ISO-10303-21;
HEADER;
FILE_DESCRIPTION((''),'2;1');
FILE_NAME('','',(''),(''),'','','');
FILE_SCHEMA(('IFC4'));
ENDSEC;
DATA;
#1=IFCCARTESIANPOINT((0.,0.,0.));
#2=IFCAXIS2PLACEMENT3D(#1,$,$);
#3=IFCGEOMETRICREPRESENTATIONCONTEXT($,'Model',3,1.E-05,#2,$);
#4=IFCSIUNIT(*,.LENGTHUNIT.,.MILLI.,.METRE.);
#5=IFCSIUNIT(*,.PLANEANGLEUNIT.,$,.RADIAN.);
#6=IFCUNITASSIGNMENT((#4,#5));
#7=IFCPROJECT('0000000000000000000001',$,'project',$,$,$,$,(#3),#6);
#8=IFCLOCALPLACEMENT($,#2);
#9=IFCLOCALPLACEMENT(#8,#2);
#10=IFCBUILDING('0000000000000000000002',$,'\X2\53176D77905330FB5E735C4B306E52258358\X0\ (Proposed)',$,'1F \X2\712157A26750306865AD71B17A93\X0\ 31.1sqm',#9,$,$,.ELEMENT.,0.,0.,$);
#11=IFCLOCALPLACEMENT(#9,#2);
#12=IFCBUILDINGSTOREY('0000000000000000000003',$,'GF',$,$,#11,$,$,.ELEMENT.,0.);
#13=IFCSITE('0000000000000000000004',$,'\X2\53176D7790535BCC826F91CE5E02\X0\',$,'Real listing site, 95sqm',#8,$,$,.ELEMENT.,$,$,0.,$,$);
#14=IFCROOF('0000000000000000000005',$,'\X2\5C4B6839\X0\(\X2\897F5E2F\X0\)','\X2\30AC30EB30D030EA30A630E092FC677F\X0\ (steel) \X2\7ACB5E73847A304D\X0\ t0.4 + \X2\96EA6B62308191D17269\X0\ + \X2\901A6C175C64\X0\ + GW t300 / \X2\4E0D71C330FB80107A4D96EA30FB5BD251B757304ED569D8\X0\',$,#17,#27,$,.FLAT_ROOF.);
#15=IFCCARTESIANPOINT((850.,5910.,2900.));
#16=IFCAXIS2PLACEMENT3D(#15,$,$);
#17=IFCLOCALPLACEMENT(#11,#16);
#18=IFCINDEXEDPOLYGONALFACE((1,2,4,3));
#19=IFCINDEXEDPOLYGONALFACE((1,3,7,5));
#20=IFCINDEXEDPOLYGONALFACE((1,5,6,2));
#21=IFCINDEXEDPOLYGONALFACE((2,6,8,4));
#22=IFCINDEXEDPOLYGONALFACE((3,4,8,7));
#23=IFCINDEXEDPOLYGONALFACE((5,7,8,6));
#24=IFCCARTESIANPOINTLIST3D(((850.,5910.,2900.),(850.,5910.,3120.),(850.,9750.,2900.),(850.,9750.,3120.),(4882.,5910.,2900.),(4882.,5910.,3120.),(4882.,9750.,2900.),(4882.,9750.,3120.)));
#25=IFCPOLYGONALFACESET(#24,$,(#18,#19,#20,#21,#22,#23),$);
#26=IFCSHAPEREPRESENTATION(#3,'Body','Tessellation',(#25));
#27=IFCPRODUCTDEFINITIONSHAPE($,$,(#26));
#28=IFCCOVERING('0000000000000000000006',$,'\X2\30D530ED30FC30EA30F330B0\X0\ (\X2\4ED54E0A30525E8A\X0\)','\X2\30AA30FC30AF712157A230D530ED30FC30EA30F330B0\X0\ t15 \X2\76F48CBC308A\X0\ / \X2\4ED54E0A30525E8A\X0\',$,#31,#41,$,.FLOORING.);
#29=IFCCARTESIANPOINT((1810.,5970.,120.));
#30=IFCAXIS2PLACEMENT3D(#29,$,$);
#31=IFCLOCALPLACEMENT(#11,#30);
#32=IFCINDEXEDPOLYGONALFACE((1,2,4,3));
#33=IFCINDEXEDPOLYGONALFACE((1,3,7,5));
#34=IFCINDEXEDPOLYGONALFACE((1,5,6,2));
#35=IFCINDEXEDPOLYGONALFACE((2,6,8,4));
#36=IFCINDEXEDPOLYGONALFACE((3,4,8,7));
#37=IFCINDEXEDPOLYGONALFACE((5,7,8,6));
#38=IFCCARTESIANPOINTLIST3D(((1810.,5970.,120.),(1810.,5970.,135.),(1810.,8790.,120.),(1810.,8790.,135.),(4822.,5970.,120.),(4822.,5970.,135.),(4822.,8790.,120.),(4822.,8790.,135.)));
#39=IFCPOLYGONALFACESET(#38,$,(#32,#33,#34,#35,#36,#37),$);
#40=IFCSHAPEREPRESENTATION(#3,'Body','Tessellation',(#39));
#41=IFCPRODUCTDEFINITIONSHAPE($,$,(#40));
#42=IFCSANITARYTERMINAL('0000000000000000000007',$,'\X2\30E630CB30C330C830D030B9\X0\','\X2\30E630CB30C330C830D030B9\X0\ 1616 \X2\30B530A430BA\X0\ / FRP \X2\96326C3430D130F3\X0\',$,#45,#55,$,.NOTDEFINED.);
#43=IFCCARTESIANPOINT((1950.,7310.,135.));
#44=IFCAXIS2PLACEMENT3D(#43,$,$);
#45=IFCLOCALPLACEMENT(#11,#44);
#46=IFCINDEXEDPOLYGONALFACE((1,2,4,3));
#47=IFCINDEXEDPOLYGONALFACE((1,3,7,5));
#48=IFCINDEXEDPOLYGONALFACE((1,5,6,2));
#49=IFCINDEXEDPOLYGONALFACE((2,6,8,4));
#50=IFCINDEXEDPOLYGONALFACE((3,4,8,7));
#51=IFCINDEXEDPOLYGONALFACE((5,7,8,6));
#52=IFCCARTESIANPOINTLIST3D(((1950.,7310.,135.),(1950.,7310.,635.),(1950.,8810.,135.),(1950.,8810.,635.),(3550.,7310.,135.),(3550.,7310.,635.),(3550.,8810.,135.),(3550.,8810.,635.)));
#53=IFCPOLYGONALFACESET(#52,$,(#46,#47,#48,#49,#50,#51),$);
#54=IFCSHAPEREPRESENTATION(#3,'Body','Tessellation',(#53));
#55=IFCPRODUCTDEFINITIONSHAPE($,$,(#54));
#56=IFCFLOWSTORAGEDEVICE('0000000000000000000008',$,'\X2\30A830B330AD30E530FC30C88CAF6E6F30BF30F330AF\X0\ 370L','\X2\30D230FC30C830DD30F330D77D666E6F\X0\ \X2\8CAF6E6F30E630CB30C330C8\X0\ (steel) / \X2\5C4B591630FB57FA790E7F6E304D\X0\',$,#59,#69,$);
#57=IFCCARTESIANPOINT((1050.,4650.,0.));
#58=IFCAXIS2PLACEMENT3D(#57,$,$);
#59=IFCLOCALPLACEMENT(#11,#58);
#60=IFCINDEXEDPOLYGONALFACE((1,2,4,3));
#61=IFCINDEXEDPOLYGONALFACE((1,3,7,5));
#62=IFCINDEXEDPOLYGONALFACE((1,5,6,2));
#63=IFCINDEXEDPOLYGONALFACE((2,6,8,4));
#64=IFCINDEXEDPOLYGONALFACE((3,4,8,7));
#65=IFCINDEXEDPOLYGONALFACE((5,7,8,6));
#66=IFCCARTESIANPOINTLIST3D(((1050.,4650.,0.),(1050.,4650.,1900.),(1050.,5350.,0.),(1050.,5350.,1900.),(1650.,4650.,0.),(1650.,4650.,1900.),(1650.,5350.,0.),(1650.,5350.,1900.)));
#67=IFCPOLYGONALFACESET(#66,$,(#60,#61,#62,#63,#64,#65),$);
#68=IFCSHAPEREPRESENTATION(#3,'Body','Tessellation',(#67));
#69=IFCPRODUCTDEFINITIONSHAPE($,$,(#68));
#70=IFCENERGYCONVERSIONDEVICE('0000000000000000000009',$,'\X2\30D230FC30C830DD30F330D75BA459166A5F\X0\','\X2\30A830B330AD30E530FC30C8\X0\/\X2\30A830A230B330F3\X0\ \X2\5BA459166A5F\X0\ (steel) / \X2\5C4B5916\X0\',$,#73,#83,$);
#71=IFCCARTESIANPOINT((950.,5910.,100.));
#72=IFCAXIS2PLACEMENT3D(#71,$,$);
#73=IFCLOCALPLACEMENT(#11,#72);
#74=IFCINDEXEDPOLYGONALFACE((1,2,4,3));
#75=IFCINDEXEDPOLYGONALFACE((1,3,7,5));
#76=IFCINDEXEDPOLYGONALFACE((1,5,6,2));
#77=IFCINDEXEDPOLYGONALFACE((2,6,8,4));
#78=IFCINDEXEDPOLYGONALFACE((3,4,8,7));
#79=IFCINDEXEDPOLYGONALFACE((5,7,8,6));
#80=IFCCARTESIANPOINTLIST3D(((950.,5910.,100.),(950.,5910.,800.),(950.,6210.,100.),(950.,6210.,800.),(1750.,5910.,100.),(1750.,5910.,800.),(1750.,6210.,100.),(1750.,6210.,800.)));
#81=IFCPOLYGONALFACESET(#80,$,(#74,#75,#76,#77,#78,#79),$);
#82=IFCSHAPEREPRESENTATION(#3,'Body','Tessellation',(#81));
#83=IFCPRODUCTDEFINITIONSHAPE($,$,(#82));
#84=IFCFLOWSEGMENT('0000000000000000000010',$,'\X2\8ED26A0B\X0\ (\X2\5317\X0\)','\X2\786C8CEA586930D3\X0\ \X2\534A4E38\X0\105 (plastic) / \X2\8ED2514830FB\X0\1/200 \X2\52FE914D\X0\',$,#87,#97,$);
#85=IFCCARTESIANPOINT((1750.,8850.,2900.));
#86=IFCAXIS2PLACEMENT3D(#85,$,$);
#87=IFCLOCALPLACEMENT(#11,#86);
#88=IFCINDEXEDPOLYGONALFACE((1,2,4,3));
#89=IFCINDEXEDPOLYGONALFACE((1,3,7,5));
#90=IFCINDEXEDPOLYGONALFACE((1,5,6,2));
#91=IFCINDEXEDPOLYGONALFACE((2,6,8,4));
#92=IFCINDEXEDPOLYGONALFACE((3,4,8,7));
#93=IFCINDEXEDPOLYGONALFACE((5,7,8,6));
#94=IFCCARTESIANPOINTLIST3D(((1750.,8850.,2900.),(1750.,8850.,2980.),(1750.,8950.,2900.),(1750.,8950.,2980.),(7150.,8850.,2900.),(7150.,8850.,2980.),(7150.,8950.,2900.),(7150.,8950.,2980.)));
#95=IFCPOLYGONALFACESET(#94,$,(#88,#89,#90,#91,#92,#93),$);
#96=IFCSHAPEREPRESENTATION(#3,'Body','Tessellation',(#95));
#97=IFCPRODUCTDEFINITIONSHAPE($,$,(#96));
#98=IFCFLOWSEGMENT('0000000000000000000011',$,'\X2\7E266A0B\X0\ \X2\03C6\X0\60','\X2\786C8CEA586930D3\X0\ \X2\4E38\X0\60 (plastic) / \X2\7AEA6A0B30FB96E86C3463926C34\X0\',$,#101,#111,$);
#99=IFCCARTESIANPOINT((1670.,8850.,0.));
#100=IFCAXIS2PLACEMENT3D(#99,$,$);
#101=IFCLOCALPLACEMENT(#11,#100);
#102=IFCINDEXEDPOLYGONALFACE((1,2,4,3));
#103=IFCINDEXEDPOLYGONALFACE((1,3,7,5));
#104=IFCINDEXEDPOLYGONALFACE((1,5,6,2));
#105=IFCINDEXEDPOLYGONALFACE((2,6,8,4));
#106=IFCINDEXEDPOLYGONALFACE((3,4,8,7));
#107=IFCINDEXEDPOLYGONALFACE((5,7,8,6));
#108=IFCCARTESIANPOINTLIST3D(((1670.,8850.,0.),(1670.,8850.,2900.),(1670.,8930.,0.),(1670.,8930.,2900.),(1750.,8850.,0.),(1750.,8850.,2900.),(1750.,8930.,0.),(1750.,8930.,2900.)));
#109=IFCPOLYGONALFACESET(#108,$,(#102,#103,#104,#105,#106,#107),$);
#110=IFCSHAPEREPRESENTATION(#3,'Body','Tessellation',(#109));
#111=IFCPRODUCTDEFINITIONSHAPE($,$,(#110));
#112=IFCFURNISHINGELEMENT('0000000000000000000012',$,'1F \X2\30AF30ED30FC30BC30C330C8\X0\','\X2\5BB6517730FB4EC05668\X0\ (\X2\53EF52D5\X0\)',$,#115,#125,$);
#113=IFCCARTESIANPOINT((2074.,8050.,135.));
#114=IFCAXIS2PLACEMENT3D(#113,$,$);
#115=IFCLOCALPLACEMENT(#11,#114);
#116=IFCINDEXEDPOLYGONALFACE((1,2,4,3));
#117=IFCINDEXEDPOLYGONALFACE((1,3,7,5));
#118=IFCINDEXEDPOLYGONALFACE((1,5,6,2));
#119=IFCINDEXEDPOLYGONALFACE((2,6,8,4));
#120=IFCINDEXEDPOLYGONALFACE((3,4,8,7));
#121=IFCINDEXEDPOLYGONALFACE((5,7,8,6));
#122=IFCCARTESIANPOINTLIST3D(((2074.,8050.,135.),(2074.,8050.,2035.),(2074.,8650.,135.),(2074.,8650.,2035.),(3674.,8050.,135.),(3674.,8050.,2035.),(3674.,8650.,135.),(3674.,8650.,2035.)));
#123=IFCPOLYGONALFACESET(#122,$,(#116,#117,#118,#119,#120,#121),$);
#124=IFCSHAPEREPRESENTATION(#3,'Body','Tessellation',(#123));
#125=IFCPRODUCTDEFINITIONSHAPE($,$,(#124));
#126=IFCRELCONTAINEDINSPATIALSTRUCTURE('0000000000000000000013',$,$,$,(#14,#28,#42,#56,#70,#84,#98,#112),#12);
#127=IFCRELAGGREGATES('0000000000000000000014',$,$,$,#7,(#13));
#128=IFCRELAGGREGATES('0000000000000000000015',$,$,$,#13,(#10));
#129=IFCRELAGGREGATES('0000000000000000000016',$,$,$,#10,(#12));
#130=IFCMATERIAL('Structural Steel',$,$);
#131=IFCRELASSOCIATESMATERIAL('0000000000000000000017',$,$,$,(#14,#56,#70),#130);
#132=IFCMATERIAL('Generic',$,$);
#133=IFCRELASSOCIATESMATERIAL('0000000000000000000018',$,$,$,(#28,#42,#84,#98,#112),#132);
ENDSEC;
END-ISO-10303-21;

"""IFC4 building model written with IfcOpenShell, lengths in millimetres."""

from ifc_helpers import new_model, si_unit, frame, frame_2d, origin, place, context, project, spatial, rectangle, extrude, material, element, save


model = new_model("IFC4")

# Units and contexts
model_context = context("Model", 3, precision=1e-05, world=origin())
ifc_project = project(units=[si_unit("LENGTHUNIT", "METRE", prefix="MILLI"), si_unit("PLANEANGLEUNIT", "RADIAN")], contexts=[model_context])

# Site, building, storey
site_placement = place(None, origin())
site = spatial("IfcSite", under=ifc_project, at=site_placement, Name="北海道富良野市", ObjectType="Real listing site, 95sqm", CompositionType="ELEMENT", RefElevation=0.0)
building_placement = place(site_placement, origin())
building = spatial("IfcBuilding", under=site, at=building_placement, Name="北海道・平屋の別荘 (Proposed)", ObjectType="1F 無垢材と断熱窓 31.1sqm", CompositionType="ELEMENT", ElevationOfRefHeight=0.0, ElevationOfTerrain=0.0)
storey_placement = place(building_placement, origin())
storey = spatial("IfcBuildingStorey", under=building, at=storey_placement, Name="GF", CompositionType="ELEMENT", Elevation=0.0)

# Roof
ifc_material_1 = material(Name="Structural Steel")
roof_placement = place(storey_placement, frame((850.0, 5910.0, 2900.0)))
element("IfcRoof", 1, at=roof_placement, inside=storey, material=ifc_material_1, Name="屋根(西帯)", Description="ガルバリウム鋼板 (steel) 立平葺き t0.4 + 雪止め金物 + 通気層 + GW t300 / 不燃・耐積雪・寒冷地仕様", PredefinedType="FLAT_ROOF", context=model_context, shape_type="SweptSolid", body=[
    extrude(rectangle(XDim=4032.0, YDim=3840.0, at=frame_2d((2016.0, 1920.0))), frame((850.0, 5910.0, 2900.0)), (0.0, 0.0, 1.0), 220.0),
])

# Covering
ifc_material_2 = material(Name="Generic")
covering_placement = place(storey_placement, frame((1810.0, 5970.0, 120.0)))
element("IfcCovering", 2, at=covering_placement, inside=storey, material=ifc_material_2, Name="フローリング (仕上げ床)", Description="オーク無垢フローリング t15 直貼り / 仕上げ床", PredefinedType="FLOORING", context=model_context, shape_type="SweptSolid", body=[
    extrude(rectangle(XDim=3012.0, YDim=2820.0, at=frame_2d((1506.0, 1410.0))), frame((1810.0, 5970.0, 120.0)), (0.0, 0.0, 1.0), 15.0),
])

# Sanitary terminal
sanitary_terminal_placement = place(storey_placement, frame((1950.0, 7310.0, 135.0)))
element("IfcSanitaryTerminal", 3, at=sanitary_terminal_placement, inside=storey, material=ifc_material_2, Name="ユニットバス", Description="ユニットバス 1616 サイズ / FRP 防水パン", PredefinedType="NOTDEFINED", context=model_context, shape_type="SweptSolid", body=[
    extrude(rectangle(XDim=1600.0, YDim=1500.0, at=frame_2d((800.0, 750.0))), frame((1950.0, 7310.0, 135.0)), (0.0, 0.0, 1.0), 500.0),
])

# Flow storage device
flow_storage_device_placement = place(storey_placement, frame((1050.0, 4650.0, 0.0)))
element("IfcFlowStorageDevice", 4, at=flow_storage_device_placement, inside=storey, material=ifc_material_1, Name="エコキュート貯湯タンク 370L", Description="ヒートポンプ給湯 貯湯ユニット (steel) / 屋外・基礎置き", context=model_context, shape_type="SweptSolid", body=[
    extrude(rectangle(XDim=600.0, YDim=700.0, at=frame_2d((300.0, 350.0))), frame((1050.0, 4650.0, 0.0)), (0.0, 0.0, 1.0), 1900.0),
])

# Energy conversion device
energy_conversion_device_placement = place(storey_placement, frame((950.0, 5910.0, 100.0)))
element("IfcEnergyConversionDevice", 5, at=energy_conversion_device_placement, inside=storey, material=ifc_material_1, Name="ヒートポンプ室外機", Description="エコキュート/エアコン 室外機 (steel) / 屋外", context=model_context, shape_type="SweptSolid", body=[
    extrude(rectangle(XDim=800.0, YDim=300.0, at=frame_2d((400.0, 150.0))), frame((950.0, 5910.0, 100.0)), (0.0, 0.0, 1.0), 700.0),
])

# Flow segments
flow_segment_1_placement = place(storey_placement, frame((1750.0, 8850.0, 2900.0)))
element("IfcFlowSegment", 6, at=flow_segment_1_placement, inside=storey, material=ifc_material_2, Name="軒樋 (北)", Description="硬質塩ビ 半丸105 (plastic) / 軒先・1/200 勾配", context=model_context, shape_type="SweptSolid", body=[
    extrude(rectangle(XDim=5400.0, YDim=100.0, at=frame_2d((2700.0, 50.0))), frame((1750.0, 8850.0, 2900.0)), (0.0, 0.0, 1.0), 80.0),
])
flow_segment_2_placement = place(storey_placement, frame((1670.0, 8850.0, 0.0)))
element("IfcFlowSegment", 7, at=flow_segment_2_placement, inside=storey, material=ifc_material_2, Name="縦樋 φ60", Description="硬質塩ビ 丸60 (plastic) / 竪樋・雨水排水", context=model_context, shape_type="SweptSolid", body=[
    extrude(rectangle(XDim=80.0, YDim=80.0, at=frame_2d((40.0, 40.0))), frame((1670.0, 8850.0, 0.0)), (0.0, 0.0, 1.0), 2900.0),
])

# Furnishing element
furnishing_placement = place(storey_placement, frame((2074.0, 8050.0, 135.0)))
element("IfcFurnishingElement", 8, at=furnishing_placement, inside=storey, material=ifc_material_2, Name="1F クローゼット", Description="家具・什器 (可動)", context=model_context, shape_type="SweptSolid", body=[
    extrude(rectangle(XDim=1600.0, YDim=600.0, at=frame_2d((800.0, 300.0))), frame((2074.0, 8050.0, 135.0)), (0.0, 0.0, 1.0), 1900.0),
])

save(model, "model.ifc")
